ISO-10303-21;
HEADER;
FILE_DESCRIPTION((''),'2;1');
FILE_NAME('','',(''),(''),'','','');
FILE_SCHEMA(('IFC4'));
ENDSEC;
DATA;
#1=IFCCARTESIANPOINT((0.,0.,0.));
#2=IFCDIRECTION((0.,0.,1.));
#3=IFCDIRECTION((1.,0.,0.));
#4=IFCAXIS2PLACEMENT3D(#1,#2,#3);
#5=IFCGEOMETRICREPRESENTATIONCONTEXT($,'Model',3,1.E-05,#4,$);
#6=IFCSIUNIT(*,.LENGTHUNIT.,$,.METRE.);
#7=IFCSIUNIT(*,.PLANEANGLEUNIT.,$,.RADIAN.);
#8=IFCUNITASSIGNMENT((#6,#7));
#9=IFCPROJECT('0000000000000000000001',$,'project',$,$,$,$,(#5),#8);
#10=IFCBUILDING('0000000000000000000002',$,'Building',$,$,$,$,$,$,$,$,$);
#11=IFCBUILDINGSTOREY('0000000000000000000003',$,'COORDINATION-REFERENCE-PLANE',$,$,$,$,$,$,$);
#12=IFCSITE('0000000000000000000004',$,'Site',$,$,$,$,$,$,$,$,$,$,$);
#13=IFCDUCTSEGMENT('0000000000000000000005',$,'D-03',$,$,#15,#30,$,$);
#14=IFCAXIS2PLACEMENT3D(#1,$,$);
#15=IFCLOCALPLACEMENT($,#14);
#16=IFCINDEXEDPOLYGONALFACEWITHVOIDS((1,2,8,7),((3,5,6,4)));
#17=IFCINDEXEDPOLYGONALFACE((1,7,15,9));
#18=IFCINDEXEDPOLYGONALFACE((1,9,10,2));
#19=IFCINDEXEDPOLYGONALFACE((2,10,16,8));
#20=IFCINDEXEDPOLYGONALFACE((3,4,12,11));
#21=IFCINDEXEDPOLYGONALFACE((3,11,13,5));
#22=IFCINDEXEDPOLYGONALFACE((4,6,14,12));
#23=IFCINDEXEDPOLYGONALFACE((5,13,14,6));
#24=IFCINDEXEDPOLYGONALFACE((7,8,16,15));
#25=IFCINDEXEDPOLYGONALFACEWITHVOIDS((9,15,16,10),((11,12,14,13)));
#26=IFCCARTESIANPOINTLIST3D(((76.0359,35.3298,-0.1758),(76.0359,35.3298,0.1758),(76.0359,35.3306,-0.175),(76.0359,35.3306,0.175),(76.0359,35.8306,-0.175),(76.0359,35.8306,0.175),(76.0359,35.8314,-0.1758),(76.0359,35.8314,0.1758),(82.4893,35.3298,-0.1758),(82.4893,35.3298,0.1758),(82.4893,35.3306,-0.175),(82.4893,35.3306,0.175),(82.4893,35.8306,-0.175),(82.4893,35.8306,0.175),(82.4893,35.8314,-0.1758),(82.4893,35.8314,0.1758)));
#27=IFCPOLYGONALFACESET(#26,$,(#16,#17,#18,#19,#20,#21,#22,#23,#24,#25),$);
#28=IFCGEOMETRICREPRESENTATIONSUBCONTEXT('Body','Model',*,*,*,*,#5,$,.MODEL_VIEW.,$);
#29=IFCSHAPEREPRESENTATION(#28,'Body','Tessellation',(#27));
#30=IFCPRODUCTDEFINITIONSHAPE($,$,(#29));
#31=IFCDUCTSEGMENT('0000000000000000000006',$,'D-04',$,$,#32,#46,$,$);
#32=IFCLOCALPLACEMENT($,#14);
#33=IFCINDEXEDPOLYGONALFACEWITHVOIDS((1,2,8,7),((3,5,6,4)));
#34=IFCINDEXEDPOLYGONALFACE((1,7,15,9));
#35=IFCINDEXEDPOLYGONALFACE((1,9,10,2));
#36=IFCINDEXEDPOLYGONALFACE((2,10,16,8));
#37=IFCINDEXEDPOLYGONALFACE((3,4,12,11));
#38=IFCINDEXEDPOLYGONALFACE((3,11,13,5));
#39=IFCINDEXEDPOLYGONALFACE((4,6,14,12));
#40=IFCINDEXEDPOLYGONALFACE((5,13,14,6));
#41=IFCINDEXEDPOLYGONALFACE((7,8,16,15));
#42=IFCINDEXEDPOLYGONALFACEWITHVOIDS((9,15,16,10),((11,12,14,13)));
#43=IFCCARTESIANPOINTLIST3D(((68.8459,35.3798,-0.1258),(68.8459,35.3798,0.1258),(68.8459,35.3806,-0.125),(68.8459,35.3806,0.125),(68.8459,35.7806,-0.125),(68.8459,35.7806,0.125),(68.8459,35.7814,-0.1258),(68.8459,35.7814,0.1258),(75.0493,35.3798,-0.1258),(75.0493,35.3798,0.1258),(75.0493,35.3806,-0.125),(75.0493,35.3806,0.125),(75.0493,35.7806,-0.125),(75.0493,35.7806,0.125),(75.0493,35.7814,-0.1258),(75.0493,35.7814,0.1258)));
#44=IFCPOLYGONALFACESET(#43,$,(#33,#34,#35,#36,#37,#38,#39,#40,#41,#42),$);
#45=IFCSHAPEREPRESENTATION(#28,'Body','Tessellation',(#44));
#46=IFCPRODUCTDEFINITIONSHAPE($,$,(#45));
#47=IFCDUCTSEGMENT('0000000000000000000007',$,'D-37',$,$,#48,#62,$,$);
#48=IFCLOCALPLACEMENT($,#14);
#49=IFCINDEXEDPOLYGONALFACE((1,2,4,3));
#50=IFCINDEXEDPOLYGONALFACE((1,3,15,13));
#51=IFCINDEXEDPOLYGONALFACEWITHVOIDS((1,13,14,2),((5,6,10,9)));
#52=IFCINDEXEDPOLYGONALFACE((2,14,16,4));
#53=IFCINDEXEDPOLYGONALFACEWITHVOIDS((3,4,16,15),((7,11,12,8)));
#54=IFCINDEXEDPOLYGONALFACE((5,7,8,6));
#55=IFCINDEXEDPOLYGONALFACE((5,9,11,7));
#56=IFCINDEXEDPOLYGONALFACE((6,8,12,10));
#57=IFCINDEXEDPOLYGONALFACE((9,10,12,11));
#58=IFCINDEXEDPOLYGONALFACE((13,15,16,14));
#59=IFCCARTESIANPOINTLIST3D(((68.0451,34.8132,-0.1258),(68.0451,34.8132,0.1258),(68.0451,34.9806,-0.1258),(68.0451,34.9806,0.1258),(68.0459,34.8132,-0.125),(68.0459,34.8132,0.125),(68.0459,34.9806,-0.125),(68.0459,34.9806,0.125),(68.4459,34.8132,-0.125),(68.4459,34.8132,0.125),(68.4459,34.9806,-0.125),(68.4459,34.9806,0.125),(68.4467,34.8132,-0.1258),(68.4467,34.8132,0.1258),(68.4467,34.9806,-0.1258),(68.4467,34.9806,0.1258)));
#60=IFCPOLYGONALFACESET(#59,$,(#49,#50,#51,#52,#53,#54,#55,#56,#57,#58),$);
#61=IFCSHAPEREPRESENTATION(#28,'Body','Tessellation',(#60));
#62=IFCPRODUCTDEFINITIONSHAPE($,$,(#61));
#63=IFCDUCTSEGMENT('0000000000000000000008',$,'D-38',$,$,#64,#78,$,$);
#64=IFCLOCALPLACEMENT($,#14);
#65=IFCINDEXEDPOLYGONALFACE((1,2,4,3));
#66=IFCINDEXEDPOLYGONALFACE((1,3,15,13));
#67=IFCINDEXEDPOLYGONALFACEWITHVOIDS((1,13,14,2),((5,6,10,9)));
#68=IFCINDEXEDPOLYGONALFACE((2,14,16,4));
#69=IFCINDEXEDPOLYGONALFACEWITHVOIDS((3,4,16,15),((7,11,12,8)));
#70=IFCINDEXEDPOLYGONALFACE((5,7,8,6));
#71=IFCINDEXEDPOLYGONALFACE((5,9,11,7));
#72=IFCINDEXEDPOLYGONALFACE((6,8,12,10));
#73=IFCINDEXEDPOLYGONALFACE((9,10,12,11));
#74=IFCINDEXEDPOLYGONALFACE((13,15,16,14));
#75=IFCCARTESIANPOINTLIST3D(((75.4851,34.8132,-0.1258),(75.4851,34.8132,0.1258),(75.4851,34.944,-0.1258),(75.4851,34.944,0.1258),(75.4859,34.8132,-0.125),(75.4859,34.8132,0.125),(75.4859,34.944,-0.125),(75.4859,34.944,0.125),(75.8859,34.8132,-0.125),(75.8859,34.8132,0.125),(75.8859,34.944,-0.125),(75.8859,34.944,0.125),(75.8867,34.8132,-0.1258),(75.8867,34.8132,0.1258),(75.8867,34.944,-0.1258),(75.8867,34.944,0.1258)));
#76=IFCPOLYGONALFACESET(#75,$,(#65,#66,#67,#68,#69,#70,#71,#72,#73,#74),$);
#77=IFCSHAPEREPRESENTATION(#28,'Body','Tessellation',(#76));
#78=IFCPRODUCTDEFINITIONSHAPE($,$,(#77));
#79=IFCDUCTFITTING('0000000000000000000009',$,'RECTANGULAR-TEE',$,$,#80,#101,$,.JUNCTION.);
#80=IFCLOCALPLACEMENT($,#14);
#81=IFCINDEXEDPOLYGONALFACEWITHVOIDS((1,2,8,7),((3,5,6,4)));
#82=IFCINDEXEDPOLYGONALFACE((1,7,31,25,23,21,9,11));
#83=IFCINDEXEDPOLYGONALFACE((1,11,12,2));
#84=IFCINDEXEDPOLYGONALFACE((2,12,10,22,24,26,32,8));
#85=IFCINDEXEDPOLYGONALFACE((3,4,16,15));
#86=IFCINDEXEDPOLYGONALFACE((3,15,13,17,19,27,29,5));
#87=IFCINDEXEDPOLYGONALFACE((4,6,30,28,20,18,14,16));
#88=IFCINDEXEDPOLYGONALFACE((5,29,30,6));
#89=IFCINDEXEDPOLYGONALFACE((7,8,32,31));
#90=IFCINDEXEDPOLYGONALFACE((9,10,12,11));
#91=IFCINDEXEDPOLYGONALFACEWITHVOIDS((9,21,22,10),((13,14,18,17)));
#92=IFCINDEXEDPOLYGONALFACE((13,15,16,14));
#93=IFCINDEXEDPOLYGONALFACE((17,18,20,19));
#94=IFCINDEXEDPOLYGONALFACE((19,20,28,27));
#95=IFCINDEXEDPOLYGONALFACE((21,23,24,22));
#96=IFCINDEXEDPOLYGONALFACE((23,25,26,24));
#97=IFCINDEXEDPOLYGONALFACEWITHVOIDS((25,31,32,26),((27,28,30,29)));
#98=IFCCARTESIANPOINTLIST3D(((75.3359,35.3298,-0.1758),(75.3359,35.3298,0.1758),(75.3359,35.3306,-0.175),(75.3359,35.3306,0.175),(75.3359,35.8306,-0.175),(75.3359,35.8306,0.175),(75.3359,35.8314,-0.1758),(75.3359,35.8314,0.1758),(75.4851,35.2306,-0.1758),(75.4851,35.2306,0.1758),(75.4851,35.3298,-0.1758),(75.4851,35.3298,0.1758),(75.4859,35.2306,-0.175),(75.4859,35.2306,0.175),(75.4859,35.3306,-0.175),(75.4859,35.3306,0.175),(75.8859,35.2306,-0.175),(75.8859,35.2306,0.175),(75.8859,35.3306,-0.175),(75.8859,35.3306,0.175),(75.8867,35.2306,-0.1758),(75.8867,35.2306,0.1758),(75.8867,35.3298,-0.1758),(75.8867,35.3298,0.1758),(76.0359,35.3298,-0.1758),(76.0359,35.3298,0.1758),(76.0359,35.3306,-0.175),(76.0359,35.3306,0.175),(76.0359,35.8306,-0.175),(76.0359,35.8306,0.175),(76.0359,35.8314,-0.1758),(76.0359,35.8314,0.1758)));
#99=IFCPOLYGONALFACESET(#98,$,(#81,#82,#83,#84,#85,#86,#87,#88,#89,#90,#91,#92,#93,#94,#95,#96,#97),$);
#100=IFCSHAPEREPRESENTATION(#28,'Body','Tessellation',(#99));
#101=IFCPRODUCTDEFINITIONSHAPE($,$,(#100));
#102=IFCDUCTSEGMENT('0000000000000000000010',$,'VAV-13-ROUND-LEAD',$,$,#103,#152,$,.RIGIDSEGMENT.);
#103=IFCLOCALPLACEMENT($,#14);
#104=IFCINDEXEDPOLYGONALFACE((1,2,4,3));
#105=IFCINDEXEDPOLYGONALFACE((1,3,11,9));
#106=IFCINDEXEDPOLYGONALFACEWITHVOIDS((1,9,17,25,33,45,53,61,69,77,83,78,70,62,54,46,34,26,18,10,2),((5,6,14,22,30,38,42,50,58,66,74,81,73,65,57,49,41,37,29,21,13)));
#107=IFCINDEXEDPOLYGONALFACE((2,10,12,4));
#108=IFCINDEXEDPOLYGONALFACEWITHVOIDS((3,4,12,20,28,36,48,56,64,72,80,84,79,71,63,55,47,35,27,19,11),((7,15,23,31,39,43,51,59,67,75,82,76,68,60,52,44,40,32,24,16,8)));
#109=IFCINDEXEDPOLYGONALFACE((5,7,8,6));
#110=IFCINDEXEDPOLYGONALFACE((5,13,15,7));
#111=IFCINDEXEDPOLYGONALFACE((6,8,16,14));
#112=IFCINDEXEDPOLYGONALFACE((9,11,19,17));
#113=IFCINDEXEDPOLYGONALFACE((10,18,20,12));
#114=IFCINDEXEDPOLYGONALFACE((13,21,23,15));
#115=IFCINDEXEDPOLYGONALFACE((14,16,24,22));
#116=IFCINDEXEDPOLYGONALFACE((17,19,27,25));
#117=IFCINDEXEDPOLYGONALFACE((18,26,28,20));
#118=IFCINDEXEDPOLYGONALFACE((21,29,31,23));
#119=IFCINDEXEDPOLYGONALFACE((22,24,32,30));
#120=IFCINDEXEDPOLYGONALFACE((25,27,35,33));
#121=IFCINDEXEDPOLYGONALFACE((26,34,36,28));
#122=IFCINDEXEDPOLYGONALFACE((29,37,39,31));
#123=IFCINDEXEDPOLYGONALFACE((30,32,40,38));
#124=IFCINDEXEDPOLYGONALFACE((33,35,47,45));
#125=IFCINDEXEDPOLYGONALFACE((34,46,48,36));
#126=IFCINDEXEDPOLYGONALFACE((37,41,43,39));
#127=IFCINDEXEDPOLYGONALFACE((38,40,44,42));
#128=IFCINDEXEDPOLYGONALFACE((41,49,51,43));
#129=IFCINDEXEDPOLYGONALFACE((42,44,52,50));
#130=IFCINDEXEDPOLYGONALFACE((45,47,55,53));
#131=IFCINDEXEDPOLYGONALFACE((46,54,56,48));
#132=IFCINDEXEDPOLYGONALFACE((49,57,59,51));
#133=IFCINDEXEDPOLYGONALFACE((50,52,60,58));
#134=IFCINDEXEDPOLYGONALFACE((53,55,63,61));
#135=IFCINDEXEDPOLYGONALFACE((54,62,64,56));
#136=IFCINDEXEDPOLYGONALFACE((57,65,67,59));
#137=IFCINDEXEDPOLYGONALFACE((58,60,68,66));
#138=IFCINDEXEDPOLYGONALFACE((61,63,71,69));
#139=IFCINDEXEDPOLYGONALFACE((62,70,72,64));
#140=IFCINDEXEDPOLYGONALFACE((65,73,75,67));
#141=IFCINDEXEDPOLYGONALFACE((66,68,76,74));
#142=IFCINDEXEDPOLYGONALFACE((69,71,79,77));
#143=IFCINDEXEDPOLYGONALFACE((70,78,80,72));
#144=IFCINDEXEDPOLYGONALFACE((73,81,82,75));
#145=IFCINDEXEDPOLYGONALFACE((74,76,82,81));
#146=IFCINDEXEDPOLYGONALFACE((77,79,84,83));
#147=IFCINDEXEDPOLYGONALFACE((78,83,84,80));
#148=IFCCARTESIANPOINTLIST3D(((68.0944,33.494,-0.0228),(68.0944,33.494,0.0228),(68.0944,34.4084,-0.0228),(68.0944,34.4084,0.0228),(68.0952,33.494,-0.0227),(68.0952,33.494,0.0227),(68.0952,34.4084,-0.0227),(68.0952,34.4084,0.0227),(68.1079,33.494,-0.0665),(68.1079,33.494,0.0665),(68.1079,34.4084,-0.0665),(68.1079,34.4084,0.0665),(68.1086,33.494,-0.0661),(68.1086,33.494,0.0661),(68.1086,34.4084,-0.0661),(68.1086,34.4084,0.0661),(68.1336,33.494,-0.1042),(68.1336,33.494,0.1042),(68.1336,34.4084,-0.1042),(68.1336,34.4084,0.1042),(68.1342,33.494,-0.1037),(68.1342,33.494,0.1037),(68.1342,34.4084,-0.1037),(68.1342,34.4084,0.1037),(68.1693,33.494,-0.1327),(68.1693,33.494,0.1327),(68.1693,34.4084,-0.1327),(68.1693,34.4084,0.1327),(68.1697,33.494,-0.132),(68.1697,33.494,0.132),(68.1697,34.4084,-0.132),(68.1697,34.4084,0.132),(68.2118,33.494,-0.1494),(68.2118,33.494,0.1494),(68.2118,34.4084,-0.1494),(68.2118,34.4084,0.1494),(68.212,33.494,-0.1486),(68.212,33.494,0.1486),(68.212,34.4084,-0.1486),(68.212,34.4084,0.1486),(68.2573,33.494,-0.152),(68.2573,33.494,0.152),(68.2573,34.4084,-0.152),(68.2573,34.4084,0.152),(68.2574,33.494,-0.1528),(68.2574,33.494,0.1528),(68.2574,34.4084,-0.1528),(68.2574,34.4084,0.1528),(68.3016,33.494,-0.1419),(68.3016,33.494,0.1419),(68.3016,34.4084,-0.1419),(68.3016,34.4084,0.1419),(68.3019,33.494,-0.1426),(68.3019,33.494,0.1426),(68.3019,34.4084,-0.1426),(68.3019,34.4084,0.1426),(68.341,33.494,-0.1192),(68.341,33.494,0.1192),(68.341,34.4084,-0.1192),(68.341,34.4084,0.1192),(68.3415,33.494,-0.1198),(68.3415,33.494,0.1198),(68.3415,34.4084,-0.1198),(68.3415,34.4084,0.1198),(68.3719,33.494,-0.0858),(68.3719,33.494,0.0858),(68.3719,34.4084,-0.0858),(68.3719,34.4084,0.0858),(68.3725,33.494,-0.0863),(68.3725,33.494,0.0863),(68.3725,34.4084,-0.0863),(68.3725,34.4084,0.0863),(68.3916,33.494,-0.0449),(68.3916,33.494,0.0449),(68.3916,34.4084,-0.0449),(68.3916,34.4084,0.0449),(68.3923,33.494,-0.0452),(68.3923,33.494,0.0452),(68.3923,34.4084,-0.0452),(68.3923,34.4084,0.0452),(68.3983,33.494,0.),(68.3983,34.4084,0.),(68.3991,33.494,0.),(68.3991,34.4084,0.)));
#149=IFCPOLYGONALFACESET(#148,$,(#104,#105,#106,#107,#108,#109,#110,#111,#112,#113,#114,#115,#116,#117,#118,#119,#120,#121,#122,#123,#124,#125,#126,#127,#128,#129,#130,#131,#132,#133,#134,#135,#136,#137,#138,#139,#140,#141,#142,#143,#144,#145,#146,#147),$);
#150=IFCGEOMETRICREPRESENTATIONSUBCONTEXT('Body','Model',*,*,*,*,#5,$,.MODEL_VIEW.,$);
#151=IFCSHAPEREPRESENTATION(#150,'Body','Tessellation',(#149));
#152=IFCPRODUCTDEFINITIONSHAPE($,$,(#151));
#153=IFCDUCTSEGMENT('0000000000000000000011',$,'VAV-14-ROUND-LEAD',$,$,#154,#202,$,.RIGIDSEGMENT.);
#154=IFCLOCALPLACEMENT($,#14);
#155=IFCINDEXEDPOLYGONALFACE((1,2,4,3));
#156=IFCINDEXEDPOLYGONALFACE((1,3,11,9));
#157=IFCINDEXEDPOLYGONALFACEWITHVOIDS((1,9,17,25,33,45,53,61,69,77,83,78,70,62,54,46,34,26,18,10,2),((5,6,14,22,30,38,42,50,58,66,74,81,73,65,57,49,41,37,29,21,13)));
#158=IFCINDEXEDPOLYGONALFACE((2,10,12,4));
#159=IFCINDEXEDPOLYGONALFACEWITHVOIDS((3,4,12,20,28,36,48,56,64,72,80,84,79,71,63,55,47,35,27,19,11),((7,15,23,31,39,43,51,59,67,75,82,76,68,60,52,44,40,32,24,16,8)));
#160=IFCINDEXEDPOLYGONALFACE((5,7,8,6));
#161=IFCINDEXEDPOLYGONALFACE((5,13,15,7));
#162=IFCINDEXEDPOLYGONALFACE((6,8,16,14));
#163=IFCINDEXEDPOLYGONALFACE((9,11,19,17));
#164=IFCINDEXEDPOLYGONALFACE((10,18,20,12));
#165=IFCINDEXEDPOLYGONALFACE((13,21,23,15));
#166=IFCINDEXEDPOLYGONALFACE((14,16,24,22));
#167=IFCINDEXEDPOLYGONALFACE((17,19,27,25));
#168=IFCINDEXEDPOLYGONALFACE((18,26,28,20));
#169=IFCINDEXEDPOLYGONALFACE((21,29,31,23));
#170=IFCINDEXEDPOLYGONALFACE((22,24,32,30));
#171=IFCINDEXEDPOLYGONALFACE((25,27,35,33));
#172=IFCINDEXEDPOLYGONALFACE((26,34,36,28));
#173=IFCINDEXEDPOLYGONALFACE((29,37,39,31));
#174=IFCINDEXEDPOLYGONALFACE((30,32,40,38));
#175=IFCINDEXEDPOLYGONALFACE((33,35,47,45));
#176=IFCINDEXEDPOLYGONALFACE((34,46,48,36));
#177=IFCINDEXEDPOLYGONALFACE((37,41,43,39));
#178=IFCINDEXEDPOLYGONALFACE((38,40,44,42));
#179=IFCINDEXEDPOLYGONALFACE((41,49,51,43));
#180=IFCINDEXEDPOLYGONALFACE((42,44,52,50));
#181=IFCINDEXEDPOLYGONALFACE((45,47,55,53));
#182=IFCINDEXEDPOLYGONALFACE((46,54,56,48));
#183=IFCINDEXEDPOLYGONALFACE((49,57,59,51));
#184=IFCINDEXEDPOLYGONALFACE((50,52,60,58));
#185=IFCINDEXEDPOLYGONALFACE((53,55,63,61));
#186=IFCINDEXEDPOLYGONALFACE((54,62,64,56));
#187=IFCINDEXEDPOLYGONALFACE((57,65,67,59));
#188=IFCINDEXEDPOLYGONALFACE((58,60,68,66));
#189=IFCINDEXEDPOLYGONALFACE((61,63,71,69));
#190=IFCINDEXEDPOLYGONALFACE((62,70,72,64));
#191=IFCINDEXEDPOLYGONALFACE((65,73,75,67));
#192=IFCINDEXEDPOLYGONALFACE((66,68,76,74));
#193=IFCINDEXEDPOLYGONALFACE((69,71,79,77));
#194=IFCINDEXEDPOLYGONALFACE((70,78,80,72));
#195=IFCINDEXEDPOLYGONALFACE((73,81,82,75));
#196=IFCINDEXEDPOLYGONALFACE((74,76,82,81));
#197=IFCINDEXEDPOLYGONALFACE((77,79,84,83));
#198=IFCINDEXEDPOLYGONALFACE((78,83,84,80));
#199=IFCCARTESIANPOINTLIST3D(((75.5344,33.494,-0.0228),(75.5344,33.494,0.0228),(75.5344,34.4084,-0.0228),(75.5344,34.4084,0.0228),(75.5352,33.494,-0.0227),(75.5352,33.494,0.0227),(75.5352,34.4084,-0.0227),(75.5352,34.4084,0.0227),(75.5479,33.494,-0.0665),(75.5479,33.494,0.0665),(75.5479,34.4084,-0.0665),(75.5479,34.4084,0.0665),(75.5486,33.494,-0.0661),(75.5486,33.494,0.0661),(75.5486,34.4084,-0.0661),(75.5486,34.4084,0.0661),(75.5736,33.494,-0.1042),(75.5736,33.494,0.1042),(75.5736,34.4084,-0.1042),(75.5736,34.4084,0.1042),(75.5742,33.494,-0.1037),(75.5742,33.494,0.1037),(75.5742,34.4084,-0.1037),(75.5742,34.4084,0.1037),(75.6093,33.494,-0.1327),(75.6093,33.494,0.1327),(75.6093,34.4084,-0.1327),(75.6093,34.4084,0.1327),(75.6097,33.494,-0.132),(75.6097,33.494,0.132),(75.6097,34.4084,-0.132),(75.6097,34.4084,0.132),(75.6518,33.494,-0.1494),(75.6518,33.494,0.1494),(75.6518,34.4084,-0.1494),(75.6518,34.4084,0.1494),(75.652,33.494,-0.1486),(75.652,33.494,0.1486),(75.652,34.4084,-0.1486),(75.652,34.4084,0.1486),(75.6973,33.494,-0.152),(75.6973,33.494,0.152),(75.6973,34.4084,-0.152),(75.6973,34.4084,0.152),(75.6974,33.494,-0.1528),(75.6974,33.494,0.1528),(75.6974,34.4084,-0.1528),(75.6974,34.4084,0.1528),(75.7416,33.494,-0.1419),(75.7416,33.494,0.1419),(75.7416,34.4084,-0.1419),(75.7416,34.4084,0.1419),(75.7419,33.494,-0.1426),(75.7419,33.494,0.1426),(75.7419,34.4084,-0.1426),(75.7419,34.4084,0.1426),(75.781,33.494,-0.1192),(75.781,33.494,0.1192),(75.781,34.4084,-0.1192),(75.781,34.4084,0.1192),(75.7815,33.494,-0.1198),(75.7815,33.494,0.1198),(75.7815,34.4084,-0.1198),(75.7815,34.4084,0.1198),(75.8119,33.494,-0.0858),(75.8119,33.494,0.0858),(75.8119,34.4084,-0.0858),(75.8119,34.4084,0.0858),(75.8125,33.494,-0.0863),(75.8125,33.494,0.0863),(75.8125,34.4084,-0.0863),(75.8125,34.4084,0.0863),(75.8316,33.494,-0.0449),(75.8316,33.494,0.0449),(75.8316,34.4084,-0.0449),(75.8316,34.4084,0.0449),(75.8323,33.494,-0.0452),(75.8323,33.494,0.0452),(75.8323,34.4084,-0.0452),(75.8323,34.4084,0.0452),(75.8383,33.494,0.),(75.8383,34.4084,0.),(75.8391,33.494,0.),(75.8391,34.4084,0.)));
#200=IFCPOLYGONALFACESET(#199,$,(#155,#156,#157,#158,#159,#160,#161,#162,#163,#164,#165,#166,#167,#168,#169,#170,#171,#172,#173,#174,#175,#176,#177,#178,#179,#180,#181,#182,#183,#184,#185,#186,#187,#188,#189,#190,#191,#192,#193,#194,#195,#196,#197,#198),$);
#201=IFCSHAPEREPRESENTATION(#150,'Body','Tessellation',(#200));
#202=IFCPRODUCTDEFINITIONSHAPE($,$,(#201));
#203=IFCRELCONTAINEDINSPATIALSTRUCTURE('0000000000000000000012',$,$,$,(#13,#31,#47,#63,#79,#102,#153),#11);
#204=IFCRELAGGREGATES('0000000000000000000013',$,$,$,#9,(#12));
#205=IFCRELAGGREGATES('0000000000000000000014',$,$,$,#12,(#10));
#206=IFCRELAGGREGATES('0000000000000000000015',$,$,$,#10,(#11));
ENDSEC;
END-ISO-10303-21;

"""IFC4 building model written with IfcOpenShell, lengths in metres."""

from ifc_helpers import new_model, si_unit, frame, origin, origin_with_axes, place, context, subcontext, project, spatial, rectangle, hollow_rectangle, hollow_circle, extrude, boolean, element, save


model = new_model("IFC4")

# Units and contexts
model_context = context("Model", 3, precision=1e-05, world=origin_with_axes())
body_context_1 = subcontext(model_context, "Body", "Model", "MODEL_VIEW")
body_context_2 = subcontext(model_context, "Body", "Model", "MODEL_VIEW")
ifc_project = project(units=[si_unit("LENGTHUNIT", "METRE"), si_unit("PLANEANGLEUNIT", "RADIAN")], contexts=[model_context])

# Site, building, storey
site = spatial("IfcSite", under=ifc_project, Name="Site")
building = spatial("IfcBuilding", under=site, Name="Building")
storey = spatial("IfcBuildingStorey", under=building, Name="COORDINATION-REFERENCE-PLANE")

# Duct segments
duct_segment_1_placement = place(None, frame((76.0359, 35.5806, 0.0), z_axis=(1.0, 0.0, 0.0), x_axis=(0.0, 1.0, 0.0)))
element("IfcDuctSegment", 1, at=duct_segment_1_placement, inside=storey, Name="D-03", context=body_context_1, shape_type="SweptSolid", body=[
    extrude(hollow_rectangle(XDim=0.5016, YDim=0.3516, WallThickness=0.0008), origin(), (0.0, 0.0, 1.0), 6.4534),
])
duct_segment_2_placement = place(None, frame((68.8459, 35.5806, 0.0), z_axis=(1.0, 0.0, 0.0), x_axis=(0.0, 1.0, 0.0)))
element("IfcDuctSegment", 2, at=duct_segment_2_placement, inside=storey, Name="D-04", context=body_context_1, shape_type="SweptSolid", body=[
    extrude(hollow_rectangle(XDim=0.4016, YDim=0.2516, WallThickness=0.0008), origin(), (0.0, 0.0, 1.0), 6.2034),
])
duct_segment_3_placement = place(None, frame((68.2459, 34.8132, 0.0), z_axis=(0.0, 1.0, 0.0), x_axis=(1.0, 0.0, 0.0)))
element("IfcDuctSegment", 3, at=duct_segment_3_placement, inside=storey, Name="D-37", context=body_context_1, shape_type="SweptSolid", body=[
    extrude(hollow_rectangle(XDim=0.4016, YDim=0.2516, WallThickness=0.0008), origin(), (0.0, 0.0, 1.0), 0.1673),
])
duct_segment_4_placement = place(None, frame((75.6859, 34.8132, 0.0), z_axis=(0.0, 1.0, 0.0), x_axis=(1.0, 0.0, 0.0)))
element("IfcDuctSegment", 4, at=duct_segment_4_placement, inside=storey, Name="D-38", context=body_context_1, shape_type="SweptSolid", body=[
    extrude(hollow_rectangle(XDim=0.4016, YDim=0.2516, WallThickness=0.0008), origin(), (0.0, 0.0, 1.0), 0.1307),
])

# Duct fitting
duct_fitting_1_placement = place(None, frame((75.6859, 35.5806, 0.0), z_axis=(-1.0, 0.0, 0.0), x_axis=(0.0, -1.0, 0.0)))
solid = boolean("UNION", extrude(rectangle(XDim=0.5, YDim=0.35), frame((0.0, 0.0, -0.35), z_axis=(0.0, 0.0, 1.0), x_axis=(1.0, 0.0, 0.0)), (0.0, 0.0, 1.0), 0.7), extrude(rectangle(XDim=0.4, YDim=0.35), frame((0.0, 0.0, 0.0), z_axis=(1.0, 0.0, 0.0), x_axis=(0.0, 0.0, -1.0)), (0.0, 0.0, 1.0), 0.35))
element("IfcDuctFitting", 5, at=duct_fitting_1_placement, inside=storey, Name="RECTANGULAR-TEE", PredefinedType="JUNCTION", context=body_context_1, shape_type="CSG", body=[
    boolean("DIFFERENCE", boolean("UNION", extrude(rectangle(XDim=0.5016, YDim=0.3516), frame((0.0, 0.0, -0.35), z_axis=(0.0, 0.0, 1.0), x_axis=(1.0, 0.0, 0.0)), (0.0, 0.0, 1.0), 0.7), extrude(rectangle(XDim=0.4016, YDim=0.3516), frame((0.0, 0.0, 0.0), z_axis=(1.0, 0.0, 0.0), x_axis=(0.0, 0.0, -1.0)), (0.0, 0.0, 1.0), 0.35)), solid),
])

# Duct segments
for number, where, z_axis, x_axis, name in (
    (6, (68.2459, 34.4084, 0.0), (0.0, -1.0, 0.0), (1.0, 0.0, 0.0), "VAV-13-ROUND-LEAD"),
    (7, (75.6859, 34.4084, 0.0), (0.0, -1.0, 0.0), (1.0, 0.0, 0.0), "VAV-14-ROUND-LEAD"),
):
    element("IfcDuctSegment", number, at=place(None, frame(where, z_axis=z_axis, x_axis=x_axis)), inside=storey, Name=name, PredefinedType="RIGIDSEGMENT", context=body_context_2, shape_type="SweptSolid", body=[
        extrude(hollow_circle(Radius=0.1532, WallThickness=0.0008), origin(), (0.0, 0.0, 1.0), 0.9144),
    ])

save(model, "model.ifc")
